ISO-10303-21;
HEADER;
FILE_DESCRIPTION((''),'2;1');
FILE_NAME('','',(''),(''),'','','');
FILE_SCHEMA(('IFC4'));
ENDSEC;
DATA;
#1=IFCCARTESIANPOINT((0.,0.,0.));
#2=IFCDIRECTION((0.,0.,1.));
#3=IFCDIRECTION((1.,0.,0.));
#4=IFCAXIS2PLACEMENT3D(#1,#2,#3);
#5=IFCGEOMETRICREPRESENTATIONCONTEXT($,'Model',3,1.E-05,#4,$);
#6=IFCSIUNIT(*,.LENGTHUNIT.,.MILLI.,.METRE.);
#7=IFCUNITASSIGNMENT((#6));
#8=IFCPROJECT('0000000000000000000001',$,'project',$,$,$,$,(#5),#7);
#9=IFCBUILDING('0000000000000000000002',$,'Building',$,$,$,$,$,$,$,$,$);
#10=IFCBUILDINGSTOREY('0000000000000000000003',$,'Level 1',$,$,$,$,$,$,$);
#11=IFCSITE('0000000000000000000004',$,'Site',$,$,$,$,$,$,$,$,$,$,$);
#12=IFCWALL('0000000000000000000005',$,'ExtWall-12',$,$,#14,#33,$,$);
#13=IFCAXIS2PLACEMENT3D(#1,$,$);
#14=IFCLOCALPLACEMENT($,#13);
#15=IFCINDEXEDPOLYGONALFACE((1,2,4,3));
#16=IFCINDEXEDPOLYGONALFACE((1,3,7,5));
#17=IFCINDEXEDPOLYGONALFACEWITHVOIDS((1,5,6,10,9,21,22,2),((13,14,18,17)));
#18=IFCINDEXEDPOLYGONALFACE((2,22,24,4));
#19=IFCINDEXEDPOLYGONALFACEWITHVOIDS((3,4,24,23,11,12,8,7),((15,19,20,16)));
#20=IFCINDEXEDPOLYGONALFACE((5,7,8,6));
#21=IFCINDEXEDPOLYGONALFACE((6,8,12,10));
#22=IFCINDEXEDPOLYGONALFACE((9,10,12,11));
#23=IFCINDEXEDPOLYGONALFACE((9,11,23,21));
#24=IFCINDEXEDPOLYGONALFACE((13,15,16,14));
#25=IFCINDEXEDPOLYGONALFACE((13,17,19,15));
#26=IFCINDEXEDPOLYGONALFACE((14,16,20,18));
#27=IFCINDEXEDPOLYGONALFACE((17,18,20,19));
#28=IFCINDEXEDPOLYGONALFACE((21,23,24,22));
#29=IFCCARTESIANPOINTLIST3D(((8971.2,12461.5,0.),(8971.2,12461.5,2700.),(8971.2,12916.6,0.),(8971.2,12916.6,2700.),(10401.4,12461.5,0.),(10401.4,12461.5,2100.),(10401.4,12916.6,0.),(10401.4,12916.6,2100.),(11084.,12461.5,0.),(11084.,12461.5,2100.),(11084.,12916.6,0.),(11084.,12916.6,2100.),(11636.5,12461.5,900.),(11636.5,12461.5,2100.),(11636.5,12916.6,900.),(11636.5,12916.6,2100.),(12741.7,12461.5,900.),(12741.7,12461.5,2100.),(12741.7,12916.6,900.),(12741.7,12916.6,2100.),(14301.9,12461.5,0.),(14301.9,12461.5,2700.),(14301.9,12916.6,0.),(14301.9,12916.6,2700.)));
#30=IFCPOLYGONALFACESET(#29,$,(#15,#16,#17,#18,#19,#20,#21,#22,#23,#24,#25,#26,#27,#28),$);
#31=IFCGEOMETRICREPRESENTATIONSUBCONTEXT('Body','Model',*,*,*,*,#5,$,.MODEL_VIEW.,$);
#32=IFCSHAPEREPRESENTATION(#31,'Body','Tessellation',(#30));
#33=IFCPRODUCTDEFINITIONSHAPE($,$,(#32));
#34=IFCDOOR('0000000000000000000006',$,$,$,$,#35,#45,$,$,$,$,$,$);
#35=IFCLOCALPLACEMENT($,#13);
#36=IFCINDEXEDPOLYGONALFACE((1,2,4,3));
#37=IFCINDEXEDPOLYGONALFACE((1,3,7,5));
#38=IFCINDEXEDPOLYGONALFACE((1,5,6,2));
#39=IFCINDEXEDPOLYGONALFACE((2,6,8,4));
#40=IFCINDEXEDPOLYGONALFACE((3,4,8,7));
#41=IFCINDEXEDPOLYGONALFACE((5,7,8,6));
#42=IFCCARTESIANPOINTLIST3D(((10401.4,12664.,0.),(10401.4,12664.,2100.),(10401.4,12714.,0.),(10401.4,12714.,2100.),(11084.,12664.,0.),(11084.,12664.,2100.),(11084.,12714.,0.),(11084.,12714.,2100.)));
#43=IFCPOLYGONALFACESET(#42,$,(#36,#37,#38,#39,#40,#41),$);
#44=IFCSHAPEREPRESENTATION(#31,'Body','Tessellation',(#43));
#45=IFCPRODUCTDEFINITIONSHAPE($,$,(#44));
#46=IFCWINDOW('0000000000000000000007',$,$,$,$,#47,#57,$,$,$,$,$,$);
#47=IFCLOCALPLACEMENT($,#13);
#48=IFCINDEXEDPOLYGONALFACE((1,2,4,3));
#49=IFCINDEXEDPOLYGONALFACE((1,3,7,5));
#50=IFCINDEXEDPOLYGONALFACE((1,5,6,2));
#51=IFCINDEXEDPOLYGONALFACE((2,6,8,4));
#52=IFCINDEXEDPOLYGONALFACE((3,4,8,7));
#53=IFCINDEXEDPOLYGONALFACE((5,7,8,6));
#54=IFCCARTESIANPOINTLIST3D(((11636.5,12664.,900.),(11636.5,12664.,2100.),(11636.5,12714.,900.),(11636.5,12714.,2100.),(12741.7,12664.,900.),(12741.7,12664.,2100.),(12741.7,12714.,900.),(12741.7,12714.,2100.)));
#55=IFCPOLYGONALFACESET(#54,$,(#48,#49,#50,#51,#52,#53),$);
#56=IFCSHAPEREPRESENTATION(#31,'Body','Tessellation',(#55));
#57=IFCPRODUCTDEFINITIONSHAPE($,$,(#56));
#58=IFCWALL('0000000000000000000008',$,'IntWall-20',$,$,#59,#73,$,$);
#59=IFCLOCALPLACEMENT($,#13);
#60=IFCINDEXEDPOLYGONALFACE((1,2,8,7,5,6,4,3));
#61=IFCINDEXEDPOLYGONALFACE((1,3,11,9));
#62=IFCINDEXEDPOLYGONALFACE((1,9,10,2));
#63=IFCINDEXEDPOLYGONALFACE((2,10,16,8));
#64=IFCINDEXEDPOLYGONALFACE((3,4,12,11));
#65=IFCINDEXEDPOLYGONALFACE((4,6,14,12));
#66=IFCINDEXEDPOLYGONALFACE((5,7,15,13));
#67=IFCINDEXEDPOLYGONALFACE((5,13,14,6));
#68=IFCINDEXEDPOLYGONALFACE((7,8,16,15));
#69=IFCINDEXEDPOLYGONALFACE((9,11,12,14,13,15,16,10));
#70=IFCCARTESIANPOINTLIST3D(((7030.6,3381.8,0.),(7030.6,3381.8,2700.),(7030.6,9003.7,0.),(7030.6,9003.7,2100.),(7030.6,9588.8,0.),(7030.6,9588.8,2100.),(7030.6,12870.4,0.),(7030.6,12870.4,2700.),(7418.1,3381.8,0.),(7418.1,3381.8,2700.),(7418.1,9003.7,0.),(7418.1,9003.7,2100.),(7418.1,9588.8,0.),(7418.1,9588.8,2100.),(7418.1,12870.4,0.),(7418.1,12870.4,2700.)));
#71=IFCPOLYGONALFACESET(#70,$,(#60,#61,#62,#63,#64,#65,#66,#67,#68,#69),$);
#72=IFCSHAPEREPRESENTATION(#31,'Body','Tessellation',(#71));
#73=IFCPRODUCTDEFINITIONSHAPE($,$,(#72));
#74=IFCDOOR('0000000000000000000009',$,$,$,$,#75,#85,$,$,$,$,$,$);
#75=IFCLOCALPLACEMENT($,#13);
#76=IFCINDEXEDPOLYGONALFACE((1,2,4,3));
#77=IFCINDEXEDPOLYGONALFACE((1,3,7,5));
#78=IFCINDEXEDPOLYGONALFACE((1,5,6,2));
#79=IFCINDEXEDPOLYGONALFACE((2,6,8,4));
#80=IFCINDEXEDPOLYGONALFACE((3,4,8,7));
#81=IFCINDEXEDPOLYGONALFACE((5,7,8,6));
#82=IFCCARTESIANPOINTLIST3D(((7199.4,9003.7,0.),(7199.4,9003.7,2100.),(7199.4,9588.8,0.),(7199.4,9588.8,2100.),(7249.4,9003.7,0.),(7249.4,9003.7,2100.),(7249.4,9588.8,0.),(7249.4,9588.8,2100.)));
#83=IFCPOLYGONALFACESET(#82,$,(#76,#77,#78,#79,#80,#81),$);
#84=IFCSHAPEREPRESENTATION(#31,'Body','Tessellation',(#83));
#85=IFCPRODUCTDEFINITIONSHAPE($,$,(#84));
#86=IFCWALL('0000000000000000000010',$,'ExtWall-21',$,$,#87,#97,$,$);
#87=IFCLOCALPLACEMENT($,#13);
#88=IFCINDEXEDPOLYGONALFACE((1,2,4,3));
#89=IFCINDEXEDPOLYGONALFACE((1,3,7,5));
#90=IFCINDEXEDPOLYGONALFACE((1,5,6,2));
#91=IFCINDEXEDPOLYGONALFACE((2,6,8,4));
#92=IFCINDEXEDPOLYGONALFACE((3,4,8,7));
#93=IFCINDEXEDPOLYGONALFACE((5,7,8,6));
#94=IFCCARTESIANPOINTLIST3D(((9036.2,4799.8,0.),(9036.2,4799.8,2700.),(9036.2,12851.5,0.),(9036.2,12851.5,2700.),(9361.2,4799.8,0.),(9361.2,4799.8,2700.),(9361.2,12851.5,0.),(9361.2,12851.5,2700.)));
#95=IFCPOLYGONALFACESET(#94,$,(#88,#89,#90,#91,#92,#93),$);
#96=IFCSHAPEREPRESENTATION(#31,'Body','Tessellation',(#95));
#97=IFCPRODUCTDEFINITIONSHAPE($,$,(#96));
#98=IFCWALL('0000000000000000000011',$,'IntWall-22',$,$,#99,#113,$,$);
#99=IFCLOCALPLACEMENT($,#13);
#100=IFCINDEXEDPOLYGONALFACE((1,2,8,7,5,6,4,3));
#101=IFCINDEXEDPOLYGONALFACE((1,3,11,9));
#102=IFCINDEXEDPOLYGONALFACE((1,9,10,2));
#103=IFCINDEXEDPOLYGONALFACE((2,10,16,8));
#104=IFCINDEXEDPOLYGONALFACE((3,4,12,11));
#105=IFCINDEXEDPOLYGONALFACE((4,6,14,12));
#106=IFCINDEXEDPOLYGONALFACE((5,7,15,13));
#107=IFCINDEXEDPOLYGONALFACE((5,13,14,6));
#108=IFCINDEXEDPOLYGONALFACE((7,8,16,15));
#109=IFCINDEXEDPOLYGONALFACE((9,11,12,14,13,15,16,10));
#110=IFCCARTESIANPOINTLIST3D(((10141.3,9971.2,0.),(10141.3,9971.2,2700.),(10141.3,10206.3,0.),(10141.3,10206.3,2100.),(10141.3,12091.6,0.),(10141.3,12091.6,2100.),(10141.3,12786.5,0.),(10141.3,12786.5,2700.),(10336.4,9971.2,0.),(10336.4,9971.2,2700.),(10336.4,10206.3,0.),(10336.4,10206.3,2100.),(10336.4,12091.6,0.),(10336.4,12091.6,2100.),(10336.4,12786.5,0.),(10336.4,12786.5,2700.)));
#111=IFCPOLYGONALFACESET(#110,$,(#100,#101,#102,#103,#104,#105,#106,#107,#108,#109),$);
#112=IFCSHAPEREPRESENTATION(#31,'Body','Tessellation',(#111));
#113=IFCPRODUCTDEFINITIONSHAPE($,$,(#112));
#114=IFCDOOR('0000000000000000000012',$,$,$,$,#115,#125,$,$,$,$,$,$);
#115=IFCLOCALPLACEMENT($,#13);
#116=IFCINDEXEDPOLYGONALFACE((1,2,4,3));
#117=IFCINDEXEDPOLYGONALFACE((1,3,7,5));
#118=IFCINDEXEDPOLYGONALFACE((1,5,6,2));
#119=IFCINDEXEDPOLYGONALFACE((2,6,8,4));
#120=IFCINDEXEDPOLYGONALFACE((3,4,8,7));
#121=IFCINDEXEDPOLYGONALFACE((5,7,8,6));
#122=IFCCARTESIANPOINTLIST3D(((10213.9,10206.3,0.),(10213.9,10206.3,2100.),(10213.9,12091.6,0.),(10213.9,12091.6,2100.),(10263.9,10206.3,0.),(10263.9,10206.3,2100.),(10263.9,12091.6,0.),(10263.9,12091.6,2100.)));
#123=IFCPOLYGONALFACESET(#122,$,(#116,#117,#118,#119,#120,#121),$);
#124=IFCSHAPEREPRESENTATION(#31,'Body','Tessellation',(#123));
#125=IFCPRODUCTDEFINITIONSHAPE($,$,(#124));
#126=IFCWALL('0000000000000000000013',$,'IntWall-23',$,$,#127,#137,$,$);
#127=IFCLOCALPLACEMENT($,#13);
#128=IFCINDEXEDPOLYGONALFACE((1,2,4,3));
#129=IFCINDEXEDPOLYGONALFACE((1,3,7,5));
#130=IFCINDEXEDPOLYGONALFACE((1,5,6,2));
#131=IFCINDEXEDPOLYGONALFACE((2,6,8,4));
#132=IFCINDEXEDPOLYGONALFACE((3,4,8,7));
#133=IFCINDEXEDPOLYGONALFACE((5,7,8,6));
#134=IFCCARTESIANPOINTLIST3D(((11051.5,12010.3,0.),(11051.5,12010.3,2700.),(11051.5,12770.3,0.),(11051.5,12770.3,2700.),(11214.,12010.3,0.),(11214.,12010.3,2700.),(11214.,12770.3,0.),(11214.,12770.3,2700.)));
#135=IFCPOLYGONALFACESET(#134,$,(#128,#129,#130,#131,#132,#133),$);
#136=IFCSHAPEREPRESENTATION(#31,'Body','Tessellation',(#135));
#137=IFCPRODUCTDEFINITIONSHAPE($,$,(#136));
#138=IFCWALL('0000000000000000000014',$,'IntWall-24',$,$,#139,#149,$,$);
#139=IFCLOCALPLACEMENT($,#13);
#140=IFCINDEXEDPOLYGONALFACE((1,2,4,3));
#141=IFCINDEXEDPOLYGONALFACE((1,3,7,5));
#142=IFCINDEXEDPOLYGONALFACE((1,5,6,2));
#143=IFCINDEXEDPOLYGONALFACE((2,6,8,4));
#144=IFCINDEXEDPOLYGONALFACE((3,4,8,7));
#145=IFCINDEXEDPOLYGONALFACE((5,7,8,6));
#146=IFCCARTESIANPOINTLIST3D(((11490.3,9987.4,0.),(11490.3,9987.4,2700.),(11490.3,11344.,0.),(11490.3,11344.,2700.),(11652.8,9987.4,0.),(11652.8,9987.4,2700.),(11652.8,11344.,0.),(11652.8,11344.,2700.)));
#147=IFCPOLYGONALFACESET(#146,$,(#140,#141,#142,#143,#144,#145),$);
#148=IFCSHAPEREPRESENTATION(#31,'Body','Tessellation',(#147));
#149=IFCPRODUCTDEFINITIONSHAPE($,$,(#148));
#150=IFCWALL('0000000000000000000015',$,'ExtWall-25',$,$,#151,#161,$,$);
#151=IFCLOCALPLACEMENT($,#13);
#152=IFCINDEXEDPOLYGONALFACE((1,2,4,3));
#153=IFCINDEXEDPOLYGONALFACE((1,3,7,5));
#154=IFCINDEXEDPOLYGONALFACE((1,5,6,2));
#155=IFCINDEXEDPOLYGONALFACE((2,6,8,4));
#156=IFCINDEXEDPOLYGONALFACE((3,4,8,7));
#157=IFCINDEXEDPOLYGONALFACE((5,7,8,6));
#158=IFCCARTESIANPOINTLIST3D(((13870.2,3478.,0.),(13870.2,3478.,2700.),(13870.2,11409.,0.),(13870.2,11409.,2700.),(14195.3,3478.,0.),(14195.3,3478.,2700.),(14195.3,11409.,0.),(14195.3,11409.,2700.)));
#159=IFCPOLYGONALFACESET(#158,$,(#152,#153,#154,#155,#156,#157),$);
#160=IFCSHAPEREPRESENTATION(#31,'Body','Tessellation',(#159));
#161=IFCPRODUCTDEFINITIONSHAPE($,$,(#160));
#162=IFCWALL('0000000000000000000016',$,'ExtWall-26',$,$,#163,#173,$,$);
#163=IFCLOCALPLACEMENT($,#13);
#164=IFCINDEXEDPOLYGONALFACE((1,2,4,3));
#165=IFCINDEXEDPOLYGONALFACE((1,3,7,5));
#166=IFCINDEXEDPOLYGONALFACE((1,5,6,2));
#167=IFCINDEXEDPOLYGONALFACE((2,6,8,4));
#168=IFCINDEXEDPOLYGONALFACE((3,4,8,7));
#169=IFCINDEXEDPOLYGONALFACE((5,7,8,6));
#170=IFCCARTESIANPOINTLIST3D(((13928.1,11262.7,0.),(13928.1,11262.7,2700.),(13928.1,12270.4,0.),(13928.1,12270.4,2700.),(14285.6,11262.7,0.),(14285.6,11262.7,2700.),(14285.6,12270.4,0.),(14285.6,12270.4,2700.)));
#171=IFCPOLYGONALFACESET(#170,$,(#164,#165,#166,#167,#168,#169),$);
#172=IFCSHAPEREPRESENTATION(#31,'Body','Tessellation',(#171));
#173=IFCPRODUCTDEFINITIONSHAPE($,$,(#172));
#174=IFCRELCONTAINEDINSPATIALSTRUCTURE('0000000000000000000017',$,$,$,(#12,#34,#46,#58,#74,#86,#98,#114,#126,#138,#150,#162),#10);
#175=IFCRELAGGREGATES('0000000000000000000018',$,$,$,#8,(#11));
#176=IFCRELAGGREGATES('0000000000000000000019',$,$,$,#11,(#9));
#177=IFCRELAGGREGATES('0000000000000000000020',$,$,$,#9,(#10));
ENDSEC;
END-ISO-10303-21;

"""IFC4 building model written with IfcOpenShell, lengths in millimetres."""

from ifc_helpers import new_model, si_unit, frame, origin_with_axes, place, context, subcontext, project, spatial, indexed_curve, outline, extrude, element, fill, save


model = new_model("IFC4")

# Units and contexts
model_context = context("Model", 3, precision=1e-05, world=origin_with_axes())
body_context = subcontext(model_context, "Body", "Model", "MODEL_VIEW")
ifc_project = project(units=[si_unit("LENGTHUNIT", "METRE", prefix="MILLI")], contexts=[model_context])

# Site, building, storey
site = spatial("IfcSite", under=ifc_project, Name="Site")
building = spatial("IfcBuilding", under=site, Name="Building")
storey = spatial("IfcBuildingStorey", under=building, Name="Level 1")

# Wall, openings, door, window
wall_1_placement = place(None, frame((8971.2, 12689.0, 0.0), z_axis=(0.0, 0.0, 1.0), x_axis=(1.0, 0.0, 0.0)))
wall_1 = element("IfcWall", 1, at=wall_1_placement, inside=storey, Name="ExtWall-12", context=body_context, shape_type="SweptSolid", body=[
    extrude(outline(indexed_curve([(0.0, 0.0), (0.0, 455.1), (5330.7, 455.1), (5330.7, 0.0), (0.0, 0.0)], self_intersect=False)), frame((0.0, -227.5, 0.0), z_axis=(0.0, 0.0, 1.0), x_axis=(1.0, 0.0, 0.0)), (0.0, 0.0, 1.0), 2700.0),
])
opening_1_placement = place(wall_1_placement, frame((1430.2, 0.0, 0.0), z_axis=(0.0, 0.0, 1.0), x_axis=(1.0, 0.0, 0.0)))
opening_1 = element("IfcOpeningElement", 2, at=opening_1_placement, cuts=wall_1, context=body_context, shape_type="SweptSolid", body=[
    extrude(outline(indexed_curve([(0.0, 0.0), (0.0, 555.1), (682.6, 555.1), (682.6, 0.0), (0.0, 0.0)], self_intersect=False)), frame((0.0, -277.5, 0.0), z_axis=(0.0, 0.0, 1.0), x_axis=(1.0, 0.0, 0.0)), (0.0, 0.0, 1.0), 2100.0),
])
opening_2_placement = place(wall_1_placement, frame((2665.4, 0.0, 900.0), z_axis=(0.0, 0.0, 1.0), x_axis=(1.0, 0.0, 0.0)))
opening_2 = element("IfcOpeningElement", 3, at=opening_2_placement, cuts=wall_1, context=body_context, shape_type="SweptSolid", body=[
    extrude(outline(indexed_curve([(0.0, 0.0), (0.0, 555.1), (1105.1, 555.1), (1105.1, 0.0), (0.0, 0.0)], self_intersect=False)), frame((0.0, -277.5, 0.0), z_axis=(0.0, 0.0, 1.0), x_axis=(1.0, 0.0, 0.0)), (0.0, 0.0, 1.0), 1200.0),
])
door_1_placement = place(opening_1_placement, origin_with_axes())
door_1 = element("IfcDoor", 4, at=door_1_placement, inside=storey, context=body_context, shape_type="SweptSolid", body=[
    extrude(outline(indexed_curve([(0.0, 0.0), (0.0, 50.0), (682.6, 50.0), (682.6, 0.0), (0.0, 0.0)], self_intersect=False)), frame((0.0, -25.0, 0.0), z_axis=(0.0, 0.0, 1.0), x_axis=(1.0, 0.0, 0.0)), (0.0, 0.0, 1.0), 2100.0),
])
fill(opening_1, door_1)
window_1_placement = place(opening_2_placement, origin_with_axes())
window_1 = element("IfcWindow", 5, at=window_1_placement, inside=storey, context=body_context, shape_type="SweptSolid", body=[
    extrude(outline(indexed_curve([(0.0, 0.0), (0.0, 50.0), (1105.1, 50.0), (1105.1, 0.0), (0.0, 0.0)], self_intersect=False)), frame((0.0, -25.0, 0.0), z_axis=(0.0, 0.0, 1.0), x_axis=(1.0, 0.0, 0.0)), (0.0, 0.0, 1.0), 1200.0),
])
fill(opening_2, window_1)

# Wall, opening, door
wall_2_placement = place(None, frame((7224.4, 3381.8, 0.0), z_axis=(0.0, 0.0, 1.0), x_axis=(0.0, 1.0, 0.0)))
wall_2 = element("IfcWall", 6, at=wall_2_placement, inside=storey, Name="IntWall-20", context=body_context, shape_type="SweptSolid", body=[
    extrude(outline(indexed_curve([(0.0, 0.0), (0.0, 387.4), (9488.6, 387.4), (9488.6, 0.0), (0.0, 0.0)], self_intersect=False)), frame((0.0, -193.7, 0.0), z_axis=(0.0, 0.0, 1.0), x_axis=(1.0, 0.0, 0.0)), (0.0, 0.0, 1.0), 2700.0),
])
opening_3_placement = place(wall_2_placement, frame((5621.9, 0.0, 0.0), z_axis=(0.0, 0.0, 1.0), x_axis=(1.0, 0.0, 0.0)))
opening_3 = element("IfcOpeningElement", 7, at=opening_3_placement, cuts=wall_2, context=body_context, shape_type="SweptSolid", body=[
    extrude(outline(indexed_curve([(0.0, 0.0), (0.0, 487.4), (585.1, 487.4), (585.1, 0.0), (0.0, 0.0)], self_intersect=False)), frame((0.0, -243.7, 0.0), z_axis=(0.0, 0.0, 1.0), x_axis=(1.0, 0.0, 0.0)), (0.0, 0.0, 1.0), 2100.0),
])
door_2_placement = place(opening_3_placement, origin_with_axes())
door_2 = element("IfcDoor", 8, at=door_2_placement, inside=storey, context=body_context, shape_type="SweptSolid", body=[
    extrude(outline(indexed_curve([(0.0, 0.0), (0.0, 50.0), (585.1, 50.0), (585.1, 0.0), (0.0, 0.0)], self_intersect=False)), frame((0.0, -25.0, 0.0), z_axis=(0.0, 0.0, 1.0), x_axis=(1.0, 0.0, 0.0)), (0.0, 0.0, 1.0), 2100.0),
])
fill(opening_3, door_2)

# Wall
wall_3_placement = place(None, frame((9198.7, 4799.8, 0.0), z_axis=(0.0, 0.0, 1.0), x_axis=(0.0, 1.0, 0.0)))
element("IfcWall", 9, at=wall_3_placement, inside=storey, Name="ExtWall-21", context=body_context, shape_type="SweptSolid", body=[
    extrude(outline(indexed_curve([(0.0, 0.0), (0.0, 325.0), (8051.7, 325.0), (8051.7, 0.0), (0.0, 0.0)], self_intersect=False)), frame((0.0, -162.5, 0.0), z_axis=(0.0, 0.0, 1.0), x_axis=(1.0, 0.0, 0.0)), (0.0, 0.0, 1.0), 2700.0),
])

# Wall, opening, door
wall_4_placement = place(None, frame((10238.9, 9971.2, 0.0), z_axis=(0.0, 0.0, 1.0), x_axis=(0.0, 1.0, 0.0)))
wall_4 = element("IfcWall", 10, at=wall_4_placement, inside=storey, Name="IntWall-22", context=body_context, shape_type="SweptSolid", body=[
    extrude(outline(indexed_curve([(0.0, 0.0), (0.0, 195.0), (2815.4, 195.0), (2815.4, 0.0), (0.0, 0.0)], self_intersect=False)), frame((0.0, -97.5, 0.0), z_axis=(0.0, 0.0, 1.0), x_axis=(1.0, 0.0, 0.0)), (0.0, 0.0, 1.0), 2700.0),
])
opening_4_placement = place(wall_4_placement, frame((235.2, 0.0, 0.0), z_axis=(0.0, 0.0, 1.0), x_axis=(1.0, 0.0, 0.0)))
opening_4 = element("IfcOpeningElement", 11, at=opening_4_placement, cuts=wall_4, context=body_context, shape_type="SweptSolid", body=[
    extrude(outline(indexed_curve([(0.0, 0.0), (0.0, 295.0), (1885.2, 295.0), (1885.2, 0.0), (0.0, 0.0)], self_intersect=False)), frame((0.0, -147.5, 0.0), z_axis=(0.0, 0.0, 1.0), x_axis=(1.0, 0.0, 0.0)), (0.0, 0.0, 1.0), 2100.0),
])
door_3_placement = place(opening_4_placement, origin_with_axes())
door_3 = element("IfcDoor", 12, at=door_3_placement, inside=storey, context=body_context, shape_type="SweptSolid", body=[
    extrude(outline(indexed_curve([(0.0, 0.0), (0.0, 50.0), (1885.2, 50.0), (1885.2, 0.0), (0.0, 0.0)], self_intersect=False)), frame((0.0, -25.0, 0.0), z_axis=(0.0, 0.0, 1.0), x_axis=(1.0, 0.0, 0.0)), (0.0, 0.0, 1.0), 2100.0),
])
fill(opening_4, door_3)

# Walls
wall_5_placement = place(None, frame((11132.7, 12010.3, 0.0), z_axis=(0.0, 0.0, 1.0), x_axis=(0.0, 1.0, 0.0)))
element("IfcWall", 13, at=wall_5_placement, inside=storey, Name="IntWall-23", context=body_context, shape_type="SweptSolid", body=[
    extrude(outline(indexed_curve([(0.0, 0.0), (0.0, 162.5), (760.0, 162.5), (760.0, 0.0), (0.0, 0.0)], self_intersect=False)), frame((0.0, -81.3, 0.0), z_axis=(0.0, 0.0, 1.0), x_axis=(1.0, 0.0, 0.0)), (0.0, 0.0, 1.0), 2700.0),
])
wall_6_placement = place(None, frame((11571.5, 9987.4, 0.0), z_axis=(0.0, 0.0, 1.0), x_axis=(0.0, 1.0, 0.0)))
element("IfcWall", 14, at=wall_6_placement, inside=storey, Name="IntWall-24", context=body_context, shape_type="SweptSolid", body=[
    extrude(outline(indexed_curve([(0.0, 0.0), (0.0, 162.5), (1356.6, 162.5), (1356.6, 0.0), (0.0, 0.0)], self_intersect=False)), frame((0.0, -81.3, 0.0), z_axis=(0.0, 0.0, 1.0), x_axis=(1.0, 0.0, 0.0)), (0.0, 0.0, 1.0), 2700.0),
])
wall_7_placement = place(None, frame((14032.8, 3478.0, 0.0), z_axis=(0.0, 0.0, 1.0), x_axis=(0.0, 1.0, 0.0)))
element("IfcWall", 15, at=wall_7_placement, inside=storey, Name="ExtWall-25", context=body_context, shape_type="SweptSolid", body=[
    extrude(outline(indexed_curve([(0.0, 0.0), (0.0, 325.0), (7931.0, 325.0), (7931.0, 0.0), (0.0, 0.0)], self_intersect=False)), frame((0.0, -162.5, 0.0), z_axis=(0.0, 0.0, 1.0), x_axis=(1.0, 0.0, 0.0)), (0.0, 0.0, 1.0), 2700.0),
])
wall_8_placement = place(None, frame((14106.9, 11262.7, 0.0), z_axis=(0.0, 0.0, 1.0), x_axis=(0.0, 1.0, 0.0)))
element("IfcWall", 16, at=wall_8_placement, inside=storey, Name="ExtWall-26", context=body_context, shape_type="SweptSolid", body=[
    extrude(outline(indexed_curve([(0.0, 0.0), (0.0, 357.5), (1007.6, 357.5), (1007.6, 0.0), (0.0, 0.0)], self_intersect=False)), frame((0.0, -178.8, 0.0), z_axis=(0.0, 0.0, 1.0), x_axis=(1.0, 0.0, 0.0)), (0.0, 0.0, 1.0), 2700.0),
])

save(model, "model.ifc")
